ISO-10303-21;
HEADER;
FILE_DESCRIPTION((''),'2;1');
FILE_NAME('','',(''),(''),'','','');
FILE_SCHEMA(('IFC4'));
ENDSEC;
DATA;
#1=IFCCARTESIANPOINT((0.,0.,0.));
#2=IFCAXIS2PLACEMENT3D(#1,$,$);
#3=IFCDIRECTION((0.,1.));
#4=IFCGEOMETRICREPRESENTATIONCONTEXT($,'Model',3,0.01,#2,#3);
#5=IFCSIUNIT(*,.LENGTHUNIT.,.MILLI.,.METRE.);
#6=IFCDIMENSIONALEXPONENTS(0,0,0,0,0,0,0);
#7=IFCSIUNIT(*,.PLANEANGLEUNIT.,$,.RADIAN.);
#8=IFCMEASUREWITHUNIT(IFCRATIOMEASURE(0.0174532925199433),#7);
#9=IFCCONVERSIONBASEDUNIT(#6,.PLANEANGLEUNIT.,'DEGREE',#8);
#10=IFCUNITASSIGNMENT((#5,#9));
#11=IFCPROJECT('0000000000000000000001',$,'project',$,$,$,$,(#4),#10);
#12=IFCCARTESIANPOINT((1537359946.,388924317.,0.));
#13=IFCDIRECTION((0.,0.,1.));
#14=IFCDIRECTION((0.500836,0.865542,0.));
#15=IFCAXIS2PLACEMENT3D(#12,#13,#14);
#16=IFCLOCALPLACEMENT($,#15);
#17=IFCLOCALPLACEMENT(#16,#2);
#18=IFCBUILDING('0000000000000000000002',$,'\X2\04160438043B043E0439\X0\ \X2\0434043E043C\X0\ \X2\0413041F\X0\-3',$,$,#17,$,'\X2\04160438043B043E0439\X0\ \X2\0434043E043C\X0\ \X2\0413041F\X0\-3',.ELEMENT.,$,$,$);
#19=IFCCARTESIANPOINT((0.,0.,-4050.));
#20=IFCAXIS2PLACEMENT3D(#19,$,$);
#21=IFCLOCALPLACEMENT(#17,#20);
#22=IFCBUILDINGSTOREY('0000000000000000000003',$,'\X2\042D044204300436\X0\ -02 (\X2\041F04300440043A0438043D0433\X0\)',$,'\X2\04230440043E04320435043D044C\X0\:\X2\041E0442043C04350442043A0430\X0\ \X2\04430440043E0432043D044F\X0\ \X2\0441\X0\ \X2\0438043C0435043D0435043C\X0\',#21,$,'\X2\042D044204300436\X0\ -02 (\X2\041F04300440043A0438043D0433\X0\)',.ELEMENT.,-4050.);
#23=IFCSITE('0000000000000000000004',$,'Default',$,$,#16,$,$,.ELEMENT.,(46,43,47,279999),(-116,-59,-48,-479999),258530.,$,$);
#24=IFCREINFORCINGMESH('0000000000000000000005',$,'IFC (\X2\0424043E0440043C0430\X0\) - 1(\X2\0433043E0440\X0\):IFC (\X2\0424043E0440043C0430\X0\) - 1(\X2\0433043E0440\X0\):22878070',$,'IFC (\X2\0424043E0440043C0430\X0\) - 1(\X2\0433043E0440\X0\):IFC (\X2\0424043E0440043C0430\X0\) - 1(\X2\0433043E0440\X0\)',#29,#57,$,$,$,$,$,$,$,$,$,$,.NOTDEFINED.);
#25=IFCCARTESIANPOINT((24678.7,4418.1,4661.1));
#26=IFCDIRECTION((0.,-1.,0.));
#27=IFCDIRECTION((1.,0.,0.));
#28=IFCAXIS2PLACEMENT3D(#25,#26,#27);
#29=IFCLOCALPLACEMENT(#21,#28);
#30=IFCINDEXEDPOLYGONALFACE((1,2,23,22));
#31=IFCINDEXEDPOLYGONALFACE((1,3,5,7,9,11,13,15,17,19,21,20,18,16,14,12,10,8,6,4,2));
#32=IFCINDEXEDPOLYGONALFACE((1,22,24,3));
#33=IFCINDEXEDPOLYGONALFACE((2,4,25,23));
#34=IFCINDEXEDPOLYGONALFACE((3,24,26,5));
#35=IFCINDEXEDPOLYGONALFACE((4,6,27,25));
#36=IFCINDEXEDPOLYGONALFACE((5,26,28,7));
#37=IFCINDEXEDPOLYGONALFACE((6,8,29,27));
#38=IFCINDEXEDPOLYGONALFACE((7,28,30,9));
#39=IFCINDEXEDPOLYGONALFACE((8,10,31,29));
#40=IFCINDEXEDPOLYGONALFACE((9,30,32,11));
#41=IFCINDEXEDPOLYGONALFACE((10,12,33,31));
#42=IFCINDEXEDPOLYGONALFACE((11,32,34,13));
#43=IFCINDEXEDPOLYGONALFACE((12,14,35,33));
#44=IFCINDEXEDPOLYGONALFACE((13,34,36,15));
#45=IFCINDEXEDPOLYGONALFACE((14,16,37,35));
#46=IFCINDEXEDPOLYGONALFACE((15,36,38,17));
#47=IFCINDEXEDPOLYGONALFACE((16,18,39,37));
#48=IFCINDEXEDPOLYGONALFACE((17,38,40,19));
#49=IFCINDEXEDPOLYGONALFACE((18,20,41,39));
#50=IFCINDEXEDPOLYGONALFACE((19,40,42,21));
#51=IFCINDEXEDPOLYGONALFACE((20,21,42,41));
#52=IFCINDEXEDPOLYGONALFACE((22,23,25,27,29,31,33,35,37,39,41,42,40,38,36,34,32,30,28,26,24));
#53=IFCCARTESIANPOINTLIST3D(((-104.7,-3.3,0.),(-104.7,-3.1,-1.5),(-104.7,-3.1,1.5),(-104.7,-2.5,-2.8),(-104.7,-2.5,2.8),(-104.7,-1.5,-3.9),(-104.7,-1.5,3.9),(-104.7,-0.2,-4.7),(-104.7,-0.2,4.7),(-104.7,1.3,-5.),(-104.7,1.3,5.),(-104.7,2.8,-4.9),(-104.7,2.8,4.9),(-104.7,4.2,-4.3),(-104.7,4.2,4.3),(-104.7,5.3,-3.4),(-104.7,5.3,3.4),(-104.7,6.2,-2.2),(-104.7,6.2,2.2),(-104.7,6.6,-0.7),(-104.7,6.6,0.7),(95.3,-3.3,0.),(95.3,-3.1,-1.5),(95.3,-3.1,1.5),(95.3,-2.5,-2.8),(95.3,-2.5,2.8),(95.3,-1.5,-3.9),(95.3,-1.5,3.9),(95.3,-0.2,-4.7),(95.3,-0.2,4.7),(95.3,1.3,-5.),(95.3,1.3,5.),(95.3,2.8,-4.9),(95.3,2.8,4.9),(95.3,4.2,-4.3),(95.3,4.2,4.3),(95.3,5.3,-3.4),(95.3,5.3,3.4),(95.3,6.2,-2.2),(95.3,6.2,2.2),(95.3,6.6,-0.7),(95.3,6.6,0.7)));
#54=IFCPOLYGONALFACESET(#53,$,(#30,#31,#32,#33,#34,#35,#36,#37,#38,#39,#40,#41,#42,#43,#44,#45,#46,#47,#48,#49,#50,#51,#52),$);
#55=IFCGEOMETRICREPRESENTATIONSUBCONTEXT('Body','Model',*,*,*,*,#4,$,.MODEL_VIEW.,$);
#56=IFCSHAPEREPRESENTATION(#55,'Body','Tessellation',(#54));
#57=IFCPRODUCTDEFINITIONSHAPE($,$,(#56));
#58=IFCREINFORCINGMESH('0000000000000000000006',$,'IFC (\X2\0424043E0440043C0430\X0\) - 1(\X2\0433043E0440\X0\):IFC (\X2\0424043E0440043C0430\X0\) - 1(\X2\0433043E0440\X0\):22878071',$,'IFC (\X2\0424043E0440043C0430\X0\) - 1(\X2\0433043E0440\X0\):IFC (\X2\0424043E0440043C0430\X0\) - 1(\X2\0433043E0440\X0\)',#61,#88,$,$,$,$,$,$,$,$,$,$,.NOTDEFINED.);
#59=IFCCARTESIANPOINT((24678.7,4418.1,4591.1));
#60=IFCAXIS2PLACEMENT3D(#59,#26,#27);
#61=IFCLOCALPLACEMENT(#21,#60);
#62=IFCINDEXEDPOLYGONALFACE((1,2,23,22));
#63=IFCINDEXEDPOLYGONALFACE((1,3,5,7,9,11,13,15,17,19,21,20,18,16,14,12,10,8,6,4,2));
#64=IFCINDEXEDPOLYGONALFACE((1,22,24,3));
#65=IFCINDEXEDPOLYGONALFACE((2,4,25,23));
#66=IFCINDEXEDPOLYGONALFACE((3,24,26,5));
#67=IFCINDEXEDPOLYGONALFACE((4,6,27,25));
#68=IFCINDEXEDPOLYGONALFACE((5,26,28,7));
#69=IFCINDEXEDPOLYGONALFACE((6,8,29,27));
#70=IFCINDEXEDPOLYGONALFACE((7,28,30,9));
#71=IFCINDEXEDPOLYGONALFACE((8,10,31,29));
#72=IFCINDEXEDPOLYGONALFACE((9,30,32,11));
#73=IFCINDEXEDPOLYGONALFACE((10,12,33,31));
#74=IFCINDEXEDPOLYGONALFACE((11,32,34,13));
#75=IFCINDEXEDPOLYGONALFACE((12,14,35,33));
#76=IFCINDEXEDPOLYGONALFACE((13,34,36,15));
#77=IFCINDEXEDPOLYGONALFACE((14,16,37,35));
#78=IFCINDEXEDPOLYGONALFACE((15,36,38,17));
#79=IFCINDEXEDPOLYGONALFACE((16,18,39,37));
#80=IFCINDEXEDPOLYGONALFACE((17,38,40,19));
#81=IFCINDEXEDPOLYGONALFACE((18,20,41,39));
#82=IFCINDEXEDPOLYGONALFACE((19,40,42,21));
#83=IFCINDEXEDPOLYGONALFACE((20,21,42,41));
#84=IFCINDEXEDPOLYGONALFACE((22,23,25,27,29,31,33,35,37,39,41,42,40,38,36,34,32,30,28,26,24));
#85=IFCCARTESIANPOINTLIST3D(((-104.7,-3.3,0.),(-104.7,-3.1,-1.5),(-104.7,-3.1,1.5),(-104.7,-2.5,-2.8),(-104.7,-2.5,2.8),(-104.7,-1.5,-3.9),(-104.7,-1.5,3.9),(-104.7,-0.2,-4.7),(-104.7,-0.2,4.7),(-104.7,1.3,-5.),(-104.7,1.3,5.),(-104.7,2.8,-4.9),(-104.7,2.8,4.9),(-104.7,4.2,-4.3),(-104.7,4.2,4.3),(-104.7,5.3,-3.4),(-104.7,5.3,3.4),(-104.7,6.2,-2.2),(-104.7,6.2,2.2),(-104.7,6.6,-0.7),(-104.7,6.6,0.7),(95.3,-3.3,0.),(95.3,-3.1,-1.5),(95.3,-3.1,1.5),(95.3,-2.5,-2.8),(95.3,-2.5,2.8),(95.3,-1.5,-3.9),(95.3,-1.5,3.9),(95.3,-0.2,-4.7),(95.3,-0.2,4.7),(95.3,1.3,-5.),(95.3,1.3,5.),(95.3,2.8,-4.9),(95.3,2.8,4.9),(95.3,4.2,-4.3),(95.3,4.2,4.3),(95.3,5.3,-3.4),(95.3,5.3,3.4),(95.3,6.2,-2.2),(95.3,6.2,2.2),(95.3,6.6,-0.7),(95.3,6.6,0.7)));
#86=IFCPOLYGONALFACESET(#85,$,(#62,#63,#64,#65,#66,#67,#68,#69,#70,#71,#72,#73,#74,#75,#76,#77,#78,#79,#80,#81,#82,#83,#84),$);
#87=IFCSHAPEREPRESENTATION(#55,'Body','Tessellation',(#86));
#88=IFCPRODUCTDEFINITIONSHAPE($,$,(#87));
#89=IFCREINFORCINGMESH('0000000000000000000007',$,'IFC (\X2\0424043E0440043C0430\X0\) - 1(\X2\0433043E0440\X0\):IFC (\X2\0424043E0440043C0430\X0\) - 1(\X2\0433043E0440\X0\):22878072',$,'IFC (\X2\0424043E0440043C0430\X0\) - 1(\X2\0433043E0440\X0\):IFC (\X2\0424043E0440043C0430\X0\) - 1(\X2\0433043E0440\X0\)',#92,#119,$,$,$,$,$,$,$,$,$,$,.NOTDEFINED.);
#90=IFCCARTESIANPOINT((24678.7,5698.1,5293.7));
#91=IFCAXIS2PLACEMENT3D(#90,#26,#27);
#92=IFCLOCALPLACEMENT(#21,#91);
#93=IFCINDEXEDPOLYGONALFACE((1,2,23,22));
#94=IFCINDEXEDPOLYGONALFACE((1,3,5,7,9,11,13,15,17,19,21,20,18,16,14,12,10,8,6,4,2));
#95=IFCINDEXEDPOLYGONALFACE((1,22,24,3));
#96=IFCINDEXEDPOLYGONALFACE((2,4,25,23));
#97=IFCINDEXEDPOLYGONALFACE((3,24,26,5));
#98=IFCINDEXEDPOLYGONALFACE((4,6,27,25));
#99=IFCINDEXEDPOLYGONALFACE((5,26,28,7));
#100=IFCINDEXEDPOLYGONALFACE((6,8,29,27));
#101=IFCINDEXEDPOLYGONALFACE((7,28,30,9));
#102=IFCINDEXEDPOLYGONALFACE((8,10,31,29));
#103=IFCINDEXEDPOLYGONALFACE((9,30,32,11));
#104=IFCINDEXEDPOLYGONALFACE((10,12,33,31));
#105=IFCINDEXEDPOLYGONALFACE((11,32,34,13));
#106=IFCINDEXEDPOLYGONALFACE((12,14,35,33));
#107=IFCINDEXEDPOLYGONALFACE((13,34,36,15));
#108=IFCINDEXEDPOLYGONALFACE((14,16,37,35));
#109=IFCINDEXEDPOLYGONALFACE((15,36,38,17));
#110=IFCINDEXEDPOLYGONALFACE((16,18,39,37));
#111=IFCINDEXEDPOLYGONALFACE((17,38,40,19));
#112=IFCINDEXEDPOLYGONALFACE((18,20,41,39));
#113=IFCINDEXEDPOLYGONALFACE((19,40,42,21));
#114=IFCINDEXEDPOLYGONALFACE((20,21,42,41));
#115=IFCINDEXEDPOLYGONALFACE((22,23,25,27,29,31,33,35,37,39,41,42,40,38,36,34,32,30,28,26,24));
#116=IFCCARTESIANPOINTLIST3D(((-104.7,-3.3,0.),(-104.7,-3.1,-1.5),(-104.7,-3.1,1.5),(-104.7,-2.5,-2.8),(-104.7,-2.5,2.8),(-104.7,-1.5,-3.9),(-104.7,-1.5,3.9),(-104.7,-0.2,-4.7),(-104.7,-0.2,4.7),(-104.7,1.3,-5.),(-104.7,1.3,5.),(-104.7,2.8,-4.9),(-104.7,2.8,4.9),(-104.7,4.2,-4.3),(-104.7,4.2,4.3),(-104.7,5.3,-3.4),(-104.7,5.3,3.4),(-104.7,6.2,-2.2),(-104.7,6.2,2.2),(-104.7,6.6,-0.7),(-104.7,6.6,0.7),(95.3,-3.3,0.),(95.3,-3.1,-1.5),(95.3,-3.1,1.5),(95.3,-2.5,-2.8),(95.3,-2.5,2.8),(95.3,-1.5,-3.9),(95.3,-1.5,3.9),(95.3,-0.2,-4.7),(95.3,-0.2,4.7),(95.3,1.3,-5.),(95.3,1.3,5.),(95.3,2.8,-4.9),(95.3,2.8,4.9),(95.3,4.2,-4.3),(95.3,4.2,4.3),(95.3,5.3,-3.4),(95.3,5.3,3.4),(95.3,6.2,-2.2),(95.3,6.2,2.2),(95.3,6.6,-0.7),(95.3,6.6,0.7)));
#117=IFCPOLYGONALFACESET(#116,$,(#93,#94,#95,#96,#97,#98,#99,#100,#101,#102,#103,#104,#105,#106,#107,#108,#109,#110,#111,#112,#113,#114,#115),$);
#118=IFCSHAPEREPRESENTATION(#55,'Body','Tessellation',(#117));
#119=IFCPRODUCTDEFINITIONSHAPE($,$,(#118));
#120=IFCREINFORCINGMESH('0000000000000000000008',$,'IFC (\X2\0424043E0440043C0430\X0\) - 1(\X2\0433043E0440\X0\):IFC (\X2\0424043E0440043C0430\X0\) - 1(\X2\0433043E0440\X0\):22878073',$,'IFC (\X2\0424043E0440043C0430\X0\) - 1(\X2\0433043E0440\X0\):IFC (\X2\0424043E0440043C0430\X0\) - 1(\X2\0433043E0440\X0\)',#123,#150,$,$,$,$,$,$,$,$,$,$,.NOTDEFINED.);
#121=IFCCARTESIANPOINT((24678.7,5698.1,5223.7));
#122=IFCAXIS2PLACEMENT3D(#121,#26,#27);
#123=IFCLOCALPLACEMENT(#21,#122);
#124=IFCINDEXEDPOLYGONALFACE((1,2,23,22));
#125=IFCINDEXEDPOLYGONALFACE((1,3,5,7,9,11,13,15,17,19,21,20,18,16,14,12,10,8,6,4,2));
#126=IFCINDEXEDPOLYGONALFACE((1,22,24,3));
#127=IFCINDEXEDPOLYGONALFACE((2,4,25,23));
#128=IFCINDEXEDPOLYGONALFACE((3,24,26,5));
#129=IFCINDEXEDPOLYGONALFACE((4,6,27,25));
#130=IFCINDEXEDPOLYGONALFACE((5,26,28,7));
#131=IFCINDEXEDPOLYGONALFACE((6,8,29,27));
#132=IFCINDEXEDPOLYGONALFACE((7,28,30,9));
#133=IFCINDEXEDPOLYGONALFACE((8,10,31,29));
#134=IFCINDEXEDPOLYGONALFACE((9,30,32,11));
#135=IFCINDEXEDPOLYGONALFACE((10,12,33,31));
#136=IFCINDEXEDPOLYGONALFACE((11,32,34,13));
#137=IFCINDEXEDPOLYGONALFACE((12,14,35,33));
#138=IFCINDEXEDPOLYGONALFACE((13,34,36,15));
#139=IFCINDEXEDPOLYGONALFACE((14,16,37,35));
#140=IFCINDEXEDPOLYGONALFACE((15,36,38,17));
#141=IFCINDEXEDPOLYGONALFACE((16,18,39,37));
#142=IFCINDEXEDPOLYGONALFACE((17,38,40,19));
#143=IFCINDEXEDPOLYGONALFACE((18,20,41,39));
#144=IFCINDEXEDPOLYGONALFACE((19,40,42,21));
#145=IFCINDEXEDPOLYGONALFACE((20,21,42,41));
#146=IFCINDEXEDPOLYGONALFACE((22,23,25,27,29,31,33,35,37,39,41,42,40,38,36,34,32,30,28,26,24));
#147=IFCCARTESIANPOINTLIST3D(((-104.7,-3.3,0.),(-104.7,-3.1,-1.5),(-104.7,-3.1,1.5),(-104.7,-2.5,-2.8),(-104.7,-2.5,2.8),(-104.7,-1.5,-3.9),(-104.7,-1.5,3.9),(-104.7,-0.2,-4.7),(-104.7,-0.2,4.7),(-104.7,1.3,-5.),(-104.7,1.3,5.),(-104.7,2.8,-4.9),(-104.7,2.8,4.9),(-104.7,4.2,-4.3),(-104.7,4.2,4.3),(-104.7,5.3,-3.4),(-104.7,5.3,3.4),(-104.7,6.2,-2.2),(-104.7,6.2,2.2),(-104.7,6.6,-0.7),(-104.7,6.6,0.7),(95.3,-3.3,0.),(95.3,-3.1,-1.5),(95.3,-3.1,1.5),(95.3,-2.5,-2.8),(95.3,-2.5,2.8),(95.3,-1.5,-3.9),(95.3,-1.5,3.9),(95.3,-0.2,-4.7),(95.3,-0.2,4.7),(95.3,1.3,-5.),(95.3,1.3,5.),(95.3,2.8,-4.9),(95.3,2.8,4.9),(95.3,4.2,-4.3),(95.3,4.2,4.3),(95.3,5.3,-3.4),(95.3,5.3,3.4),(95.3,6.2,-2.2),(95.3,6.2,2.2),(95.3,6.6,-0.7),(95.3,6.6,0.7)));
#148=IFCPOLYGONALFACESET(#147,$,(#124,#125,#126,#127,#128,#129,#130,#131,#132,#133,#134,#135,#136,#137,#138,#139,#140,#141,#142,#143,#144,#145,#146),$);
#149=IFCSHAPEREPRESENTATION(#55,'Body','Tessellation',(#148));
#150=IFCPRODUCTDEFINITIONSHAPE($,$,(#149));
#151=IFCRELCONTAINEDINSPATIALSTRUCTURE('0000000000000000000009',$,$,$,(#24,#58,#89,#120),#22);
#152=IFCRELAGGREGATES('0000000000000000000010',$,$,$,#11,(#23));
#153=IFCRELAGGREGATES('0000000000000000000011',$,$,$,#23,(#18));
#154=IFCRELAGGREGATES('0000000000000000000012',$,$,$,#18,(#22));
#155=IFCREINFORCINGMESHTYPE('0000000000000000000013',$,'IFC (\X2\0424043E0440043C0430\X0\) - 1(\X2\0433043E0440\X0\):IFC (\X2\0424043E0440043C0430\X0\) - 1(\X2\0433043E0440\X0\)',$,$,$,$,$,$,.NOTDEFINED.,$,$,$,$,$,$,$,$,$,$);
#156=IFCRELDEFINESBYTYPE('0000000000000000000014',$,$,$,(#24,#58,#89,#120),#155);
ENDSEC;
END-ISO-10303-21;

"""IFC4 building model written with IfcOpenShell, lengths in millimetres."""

from ifc_helpers import new_model, entity, si_unit, converted_unit, direction, frame, frame_2d, origin, place, context, subcontext, project, spatial, circle, extrude, source, transform, mapped, type_object, type_shapes, element, save


model = new_model("IFC4")

# Units and contexts
model_context = context("Model", 3, precision=0.01, world=origin(), true_north=direction((0.0, 1.0)))
body_context = subcontext(model_context, "Body", "Model", "MODEL_VIEW")
ifc_project = project(units=[si_unit("LENGTHUNIT", "METRE", prefix="MILLI"), converted_unit("PLANEANGLEUNIT", "DEGREE", entity("IfcRatioMeasure", 0.0174532925199433), si_unit("PLANEANGLEUNIT", "RADIAN"), dimensions=[0, 0, 0, 0, 0, 0, 0])], contexts=[model_context])

# Site, building, storey
site_placement = place(None, frame((1537359946.0, 388924317.0, 0.0), z_axis=(0.0, 0.0, 1.0), x_axis=(0.500836, 0.865542, 0.0)))
site = spatial("IfcSite", under=ifc_project, at=site_placement, Name="Default", CompositionType="ELEMENT", RefLatitude=(46, 43, 47, 279999), RefLongitude=(-116, -59, -48, -479999), RefElevation=258530.0)
building_placement = place(site_placement, origin())
building = spatial("IfcBuilding", under=site, at=building_placement, Name="Жилой дом ГП-3", LongName="Жилой дом ГП-3", CompositionType="ELEMENT")
storey_placement = place(building_placement, frame((0.0, 0.0, -4050.0)))
storey = spatial("IfcBuildingStorey", under=building, at=storey_placement, Name="Этаж -02 (Паркинг)", ObjectType="Уровень:Отметка уровня с именем", LongName="Этаж -02 (Паркинг)", CompositionType="ELEMENT", Elevation=-4050.0)

# Reinforcing meshes
reinforcing_mesh_type = type_object("IfcReinforcingMeshType", Name="IFC (Форма) - 1(гор):IFC (Форма) - 1(гор)", PredefinedType="NOTDEFINED")
shared_shape_1 = source(origin(), body_context, "Body", "SweptSolid", [
    extrude(circle(Radius=5.0, at=frame_2d((0.0, 0.0), x_axis=(1.0, 0.0))), frame((-104.7, 1.7, 0.0), z_axis=(1.0, 0.0, 0.0), x_axis=(0.0, -1.0, 0.0)), (0.0, 0.0, 1.0), 200.0),
])
type_shapes(reinforcing_mesh_type, [shared_shape_1])
for number, where, z_axis, x_axis, name in (
    (1, (24678.7, 4418.1, 4661.1), (0.0, -1.0, 0.0), (1.0, 0.0, 0.0), "IFC (Форма) - 1(гор):IFC (Форма) - 1(гор):22878070"),
    (2, (24678.7, 4418.1, 4591.1), (0.0, -1.0, 0.0), (1.0, 0.0, 0.0), "IFC (Форма) - 1(гор):IFC (Форма) - 1(гор):22878071"),
    (3, (24678.7, 5698.1, 5293.7), (0.0, -1.0, 0.0), (1.0, 0.0, 0.0), "IFC (Форма) - 1(гор):IFC (Форма) - 1(гор):22878072"),
    (4, (24678.7, 5698.1, 5223.7), (0.0, -1.0, 0.0), (1.0, 0.0, 0.0), "IFC (Форма) - 1(гор):IFC (Форма) - 1(гор):22878073"),
):
    element("IfcReinforcingMesh", number, at=place(storey_placement, frame(where, z_axis=z_axis, x_axis=x_axis)), inside=storey, type_object=reinforcing_mesh_type, Name=name, ObjectType="IFC (Форма) - 1(гор):IFC (Форма) - 1(гор)", PredefinedType="NOTDEFINED", context=body_context, shape_type="MappedRepresentation", body=[
        mapped(shared_shape_1, transform((0.0, 0.0, 0.0), scale=1.0)),
    ])

save(model, "model.ifc")
